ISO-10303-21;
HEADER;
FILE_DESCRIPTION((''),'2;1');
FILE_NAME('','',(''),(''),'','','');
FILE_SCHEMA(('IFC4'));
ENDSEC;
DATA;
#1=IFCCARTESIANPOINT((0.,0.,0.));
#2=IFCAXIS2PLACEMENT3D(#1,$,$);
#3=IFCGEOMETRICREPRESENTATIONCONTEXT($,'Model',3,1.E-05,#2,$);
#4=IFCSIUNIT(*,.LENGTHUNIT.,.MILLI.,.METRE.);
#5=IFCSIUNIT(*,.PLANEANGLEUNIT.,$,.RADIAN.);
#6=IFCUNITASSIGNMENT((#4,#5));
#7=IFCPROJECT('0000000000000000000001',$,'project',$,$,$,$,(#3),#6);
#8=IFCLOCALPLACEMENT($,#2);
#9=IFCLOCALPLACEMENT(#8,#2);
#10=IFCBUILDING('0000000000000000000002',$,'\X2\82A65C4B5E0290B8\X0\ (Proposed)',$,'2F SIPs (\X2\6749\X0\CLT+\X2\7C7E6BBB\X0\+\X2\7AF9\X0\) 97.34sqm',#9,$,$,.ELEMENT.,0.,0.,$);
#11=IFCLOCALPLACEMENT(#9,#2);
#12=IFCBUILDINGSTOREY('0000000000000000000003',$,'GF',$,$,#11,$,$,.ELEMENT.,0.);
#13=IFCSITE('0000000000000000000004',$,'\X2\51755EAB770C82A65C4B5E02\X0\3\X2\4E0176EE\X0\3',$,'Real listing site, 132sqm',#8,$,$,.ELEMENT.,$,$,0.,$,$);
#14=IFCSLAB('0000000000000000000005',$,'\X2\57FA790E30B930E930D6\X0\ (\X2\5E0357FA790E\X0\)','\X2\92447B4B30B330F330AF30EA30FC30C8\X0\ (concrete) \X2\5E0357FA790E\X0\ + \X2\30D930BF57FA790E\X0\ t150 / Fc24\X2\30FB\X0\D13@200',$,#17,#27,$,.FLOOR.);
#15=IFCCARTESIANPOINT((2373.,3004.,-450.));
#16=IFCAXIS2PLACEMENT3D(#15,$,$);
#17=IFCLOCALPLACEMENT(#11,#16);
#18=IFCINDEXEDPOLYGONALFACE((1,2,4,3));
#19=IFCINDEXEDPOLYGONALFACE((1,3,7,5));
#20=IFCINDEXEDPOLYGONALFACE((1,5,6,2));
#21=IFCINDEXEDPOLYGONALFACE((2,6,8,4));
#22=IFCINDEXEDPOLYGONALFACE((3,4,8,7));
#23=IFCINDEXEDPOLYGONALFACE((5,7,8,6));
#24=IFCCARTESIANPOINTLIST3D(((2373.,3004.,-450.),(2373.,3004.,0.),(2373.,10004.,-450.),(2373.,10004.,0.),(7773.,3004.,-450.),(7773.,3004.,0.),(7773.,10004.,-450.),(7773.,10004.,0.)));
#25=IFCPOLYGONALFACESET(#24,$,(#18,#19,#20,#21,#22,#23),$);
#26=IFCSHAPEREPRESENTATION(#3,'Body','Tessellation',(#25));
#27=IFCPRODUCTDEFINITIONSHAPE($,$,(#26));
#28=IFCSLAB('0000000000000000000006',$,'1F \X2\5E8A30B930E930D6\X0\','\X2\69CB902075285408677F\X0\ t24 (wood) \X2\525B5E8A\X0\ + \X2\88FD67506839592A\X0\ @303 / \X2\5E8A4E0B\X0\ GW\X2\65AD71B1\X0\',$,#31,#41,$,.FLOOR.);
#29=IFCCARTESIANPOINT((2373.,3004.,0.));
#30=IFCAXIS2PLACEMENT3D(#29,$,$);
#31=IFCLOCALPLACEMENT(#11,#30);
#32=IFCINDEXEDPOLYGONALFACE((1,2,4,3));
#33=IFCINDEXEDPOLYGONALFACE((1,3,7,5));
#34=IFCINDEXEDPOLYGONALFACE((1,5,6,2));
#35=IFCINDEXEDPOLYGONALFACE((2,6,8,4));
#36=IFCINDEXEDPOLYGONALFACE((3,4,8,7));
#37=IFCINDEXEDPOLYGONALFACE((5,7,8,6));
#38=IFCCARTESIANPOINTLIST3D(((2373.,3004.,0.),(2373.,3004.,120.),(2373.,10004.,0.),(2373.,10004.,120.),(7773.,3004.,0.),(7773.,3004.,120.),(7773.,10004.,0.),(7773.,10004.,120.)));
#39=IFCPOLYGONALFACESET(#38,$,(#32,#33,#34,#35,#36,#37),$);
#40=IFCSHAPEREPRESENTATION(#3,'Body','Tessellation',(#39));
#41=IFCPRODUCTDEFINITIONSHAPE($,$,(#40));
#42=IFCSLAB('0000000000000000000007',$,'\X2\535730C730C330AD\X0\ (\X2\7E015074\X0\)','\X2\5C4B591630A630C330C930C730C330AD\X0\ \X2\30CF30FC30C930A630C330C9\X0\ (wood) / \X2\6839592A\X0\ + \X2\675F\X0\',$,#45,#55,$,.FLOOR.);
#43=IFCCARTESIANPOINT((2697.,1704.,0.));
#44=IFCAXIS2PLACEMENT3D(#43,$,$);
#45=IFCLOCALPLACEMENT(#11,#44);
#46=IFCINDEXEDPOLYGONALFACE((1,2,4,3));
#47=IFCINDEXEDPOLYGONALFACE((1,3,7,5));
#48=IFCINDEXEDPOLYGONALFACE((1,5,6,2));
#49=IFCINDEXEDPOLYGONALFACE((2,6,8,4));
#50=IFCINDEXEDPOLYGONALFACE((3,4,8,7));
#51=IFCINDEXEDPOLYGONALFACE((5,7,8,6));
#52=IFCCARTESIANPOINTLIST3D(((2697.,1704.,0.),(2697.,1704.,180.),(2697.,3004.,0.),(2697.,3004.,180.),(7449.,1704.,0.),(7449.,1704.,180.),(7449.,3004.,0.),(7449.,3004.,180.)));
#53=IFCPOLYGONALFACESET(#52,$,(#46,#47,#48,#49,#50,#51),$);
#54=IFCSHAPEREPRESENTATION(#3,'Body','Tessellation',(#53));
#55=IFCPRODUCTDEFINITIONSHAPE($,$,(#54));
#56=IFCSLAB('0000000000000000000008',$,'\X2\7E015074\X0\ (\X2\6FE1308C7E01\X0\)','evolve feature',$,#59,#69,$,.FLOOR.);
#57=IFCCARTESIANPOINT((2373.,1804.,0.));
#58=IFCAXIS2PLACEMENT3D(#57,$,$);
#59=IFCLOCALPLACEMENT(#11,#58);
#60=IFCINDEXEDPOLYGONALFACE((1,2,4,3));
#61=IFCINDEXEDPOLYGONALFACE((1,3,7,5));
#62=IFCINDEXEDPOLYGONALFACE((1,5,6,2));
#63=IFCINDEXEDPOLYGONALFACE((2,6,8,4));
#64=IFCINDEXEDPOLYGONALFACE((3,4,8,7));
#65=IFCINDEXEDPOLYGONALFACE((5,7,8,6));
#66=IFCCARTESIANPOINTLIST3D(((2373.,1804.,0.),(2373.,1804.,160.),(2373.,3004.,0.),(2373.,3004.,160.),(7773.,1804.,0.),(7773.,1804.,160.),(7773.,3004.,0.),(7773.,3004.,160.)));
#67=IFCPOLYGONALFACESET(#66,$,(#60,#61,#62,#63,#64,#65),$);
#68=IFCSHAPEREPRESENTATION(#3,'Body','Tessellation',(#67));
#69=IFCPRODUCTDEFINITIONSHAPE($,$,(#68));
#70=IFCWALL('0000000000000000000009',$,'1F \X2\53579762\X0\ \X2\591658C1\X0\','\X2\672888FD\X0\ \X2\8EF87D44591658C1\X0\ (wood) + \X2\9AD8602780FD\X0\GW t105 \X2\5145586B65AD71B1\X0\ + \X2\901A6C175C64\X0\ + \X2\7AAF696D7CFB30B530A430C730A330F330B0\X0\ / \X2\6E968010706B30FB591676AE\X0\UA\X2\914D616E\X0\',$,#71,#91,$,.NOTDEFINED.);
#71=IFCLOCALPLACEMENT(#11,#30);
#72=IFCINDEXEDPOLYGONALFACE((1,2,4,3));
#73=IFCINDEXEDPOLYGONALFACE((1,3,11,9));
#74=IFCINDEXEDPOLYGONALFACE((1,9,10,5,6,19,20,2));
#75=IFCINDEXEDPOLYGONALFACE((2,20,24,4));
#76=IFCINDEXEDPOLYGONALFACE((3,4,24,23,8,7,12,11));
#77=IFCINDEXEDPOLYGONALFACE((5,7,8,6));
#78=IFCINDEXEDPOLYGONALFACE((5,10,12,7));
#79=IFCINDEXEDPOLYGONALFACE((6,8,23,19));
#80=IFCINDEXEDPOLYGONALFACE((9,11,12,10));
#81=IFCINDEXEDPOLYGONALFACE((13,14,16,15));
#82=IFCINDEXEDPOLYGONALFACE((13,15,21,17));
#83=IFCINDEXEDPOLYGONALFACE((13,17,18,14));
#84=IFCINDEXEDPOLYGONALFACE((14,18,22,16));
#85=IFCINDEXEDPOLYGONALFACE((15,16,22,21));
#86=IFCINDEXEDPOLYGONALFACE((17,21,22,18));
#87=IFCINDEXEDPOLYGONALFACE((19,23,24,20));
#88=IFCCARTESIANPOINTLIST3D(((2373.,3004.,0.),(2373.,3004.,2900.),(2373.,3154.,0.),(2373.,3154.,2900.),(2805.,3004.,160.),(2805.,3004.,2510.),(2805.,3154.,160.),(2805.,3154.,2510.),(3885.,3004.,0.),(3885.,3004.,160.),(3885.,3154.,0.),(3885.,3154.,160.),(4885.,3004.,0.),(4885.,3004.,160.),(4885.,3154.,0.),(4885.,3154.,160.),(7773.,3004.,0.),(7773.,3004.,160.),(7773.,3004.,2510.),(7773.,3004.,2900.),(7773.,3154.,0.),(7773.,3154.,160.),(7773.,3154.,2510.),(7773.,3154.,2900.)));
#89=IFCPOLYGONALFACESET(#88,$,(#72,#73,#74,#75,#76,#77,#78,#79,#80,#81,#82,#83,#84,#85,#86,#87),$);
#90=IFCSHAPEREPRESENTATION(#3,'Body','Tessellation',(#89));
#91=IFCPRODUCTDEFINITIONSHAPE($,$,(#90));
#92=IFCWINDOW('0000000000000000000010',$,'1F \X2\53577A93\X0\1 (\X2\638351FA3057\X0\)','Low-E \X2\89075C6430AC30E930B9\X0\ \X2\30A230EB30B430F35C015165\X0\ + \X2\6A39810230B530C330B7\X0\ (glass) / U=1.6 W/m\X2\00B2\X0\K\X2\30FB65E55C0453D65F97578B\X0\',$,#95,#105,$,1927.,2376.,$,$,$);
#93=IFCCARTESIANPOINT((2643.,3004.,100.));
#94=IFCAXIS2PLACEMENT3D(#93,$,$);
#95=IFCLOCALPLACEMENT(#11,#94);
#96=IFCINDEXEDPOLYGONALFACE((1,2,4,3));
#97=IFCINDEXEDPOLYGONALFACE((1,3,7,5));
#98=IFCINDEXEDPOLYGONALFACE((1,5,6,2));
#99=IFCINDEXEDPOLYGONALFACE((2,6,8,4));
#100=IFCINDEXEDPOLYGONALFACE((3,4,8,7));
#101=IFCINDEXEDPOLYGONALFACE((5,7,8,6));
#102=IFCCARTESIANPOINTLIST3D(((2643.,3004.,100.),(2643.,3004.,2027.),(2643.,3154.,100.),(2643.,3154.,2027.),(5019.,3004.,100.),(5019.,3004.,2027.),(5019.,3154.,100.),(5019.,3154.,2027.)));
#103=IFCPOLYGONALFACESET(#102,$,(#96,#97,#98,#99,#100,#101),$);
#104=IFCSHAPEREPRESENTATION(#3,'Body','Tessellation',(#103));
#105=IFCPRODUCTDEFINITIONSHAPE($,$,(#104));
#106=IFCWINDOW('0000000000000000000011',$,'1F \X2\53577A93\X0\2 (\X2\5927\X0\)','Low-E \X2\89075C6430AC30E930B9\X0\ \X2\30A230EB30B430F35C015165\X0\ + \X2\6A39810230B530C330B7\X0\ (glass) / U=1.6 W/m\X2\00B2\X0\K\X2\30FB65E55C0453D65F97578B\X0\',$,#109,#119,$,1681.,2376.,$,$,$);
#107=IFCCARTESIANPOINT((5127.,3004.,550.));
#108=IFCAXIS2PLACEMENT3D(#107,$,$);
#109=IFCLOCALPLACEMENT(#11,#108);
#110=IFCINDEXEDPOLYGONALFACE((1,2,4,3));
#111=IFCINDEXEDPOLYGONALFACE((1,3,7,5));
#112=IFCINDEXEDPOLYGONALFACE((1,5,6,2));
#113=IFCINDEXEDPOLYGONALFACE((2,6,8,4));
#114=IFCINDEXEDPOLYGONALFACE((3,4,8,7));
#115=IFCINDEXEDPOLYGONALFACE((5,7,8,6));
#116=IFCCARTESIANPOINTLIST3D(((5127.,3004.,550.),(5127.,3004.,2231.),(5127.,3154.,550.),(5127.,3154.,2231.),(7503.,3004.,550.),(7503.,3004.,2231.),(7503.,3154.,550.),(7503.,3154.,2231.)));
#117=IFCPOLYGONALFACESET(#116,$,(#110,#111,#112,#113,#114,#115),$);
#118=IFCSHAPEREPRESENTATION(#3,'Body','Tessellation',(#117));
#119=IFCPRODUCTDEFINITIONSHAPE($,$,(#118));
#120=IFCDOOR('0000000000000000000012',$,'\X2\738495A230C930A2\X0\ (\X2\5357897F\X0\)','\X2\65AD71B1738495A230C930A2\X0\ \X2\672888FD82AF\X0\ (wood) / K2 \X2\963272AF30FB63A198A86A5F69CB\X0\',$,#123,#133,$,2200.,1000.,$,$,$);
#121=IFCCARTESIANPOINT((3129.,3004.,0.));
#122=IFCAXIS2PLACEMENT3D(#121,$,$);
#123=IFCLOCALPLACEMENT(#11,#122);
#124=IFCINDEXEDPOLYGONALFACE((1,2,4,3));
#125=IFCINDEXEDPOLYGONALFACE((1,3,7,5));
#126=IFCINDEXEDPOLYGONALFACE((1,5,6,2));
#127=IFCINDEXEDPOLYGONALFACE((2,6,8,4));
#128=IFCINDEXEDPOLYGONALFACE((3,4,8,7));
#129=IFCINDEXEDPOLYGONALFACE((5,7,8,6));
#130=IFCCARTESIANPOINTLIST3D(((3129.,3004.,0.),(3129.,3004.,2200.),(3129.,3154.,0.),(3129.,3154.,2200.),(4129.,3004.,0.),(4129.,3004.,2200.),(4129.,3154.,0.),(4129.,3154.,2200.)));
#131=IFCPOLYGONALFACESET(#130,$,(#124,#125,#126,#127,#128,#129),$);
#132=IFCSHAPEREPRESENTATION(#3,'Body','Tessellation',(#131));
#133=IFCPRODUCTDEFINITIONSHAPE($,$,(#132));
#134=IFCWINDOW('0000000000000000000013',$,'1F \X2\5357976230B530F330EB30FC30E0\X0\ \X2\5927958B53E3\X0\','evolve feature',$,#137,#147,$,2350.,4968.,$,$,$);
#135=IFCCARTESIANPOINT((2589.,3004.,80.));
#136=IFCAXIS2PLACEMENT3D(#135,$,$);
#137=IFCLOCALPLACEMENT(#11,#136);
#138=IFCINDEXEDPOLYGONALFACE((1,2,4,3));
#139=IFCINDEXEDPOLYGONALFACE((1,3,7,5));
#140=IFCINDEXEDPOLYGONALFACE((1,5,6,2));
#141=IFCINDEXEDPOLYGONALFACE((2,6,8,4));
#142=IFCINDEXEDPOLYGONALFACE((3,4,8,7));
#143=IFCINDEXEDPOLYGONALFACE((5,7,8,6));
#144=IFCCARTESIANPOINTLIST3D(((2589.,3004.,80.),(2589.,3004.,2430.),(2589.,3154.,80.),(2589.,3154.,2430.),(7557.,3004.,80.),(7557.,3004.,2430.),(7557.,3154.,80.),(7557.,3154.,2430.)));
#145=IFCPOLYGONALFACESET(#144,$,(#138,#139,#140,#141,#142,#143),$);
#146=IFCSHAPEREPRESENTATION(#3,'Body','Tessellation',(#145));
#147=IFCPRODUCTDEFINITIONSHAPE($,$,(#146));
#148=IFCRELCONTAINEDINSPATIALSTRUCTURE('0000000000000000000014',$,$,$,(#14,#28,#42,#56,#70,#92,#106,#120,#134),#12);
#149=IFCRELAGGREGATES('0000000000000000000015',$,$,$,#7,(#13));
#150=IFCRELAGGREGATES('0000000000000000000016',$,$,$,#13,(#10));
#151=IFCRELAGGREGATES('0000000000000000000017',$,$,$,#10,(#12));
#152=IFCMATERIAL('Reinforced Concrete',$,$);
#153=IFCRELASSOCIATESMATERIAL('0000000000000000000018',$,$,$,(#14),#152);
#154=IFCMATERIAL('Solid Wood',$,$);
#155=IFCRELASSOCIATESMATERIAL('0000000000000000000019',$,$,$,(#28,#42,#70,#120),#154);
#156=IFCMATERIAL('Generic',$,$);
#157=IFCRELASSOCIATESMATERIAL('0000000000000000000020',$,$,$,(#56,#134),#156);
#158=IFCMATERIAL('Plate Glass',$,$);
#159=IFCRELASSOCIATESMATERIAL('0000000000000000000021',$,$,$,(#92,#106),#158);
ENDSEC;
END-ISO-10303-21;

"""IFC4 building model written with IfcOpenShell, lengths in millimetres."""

from ifc_helpers import new_model, si_unit, frame, frame_2d, origin, place, context, project, spatial, rectangle, extrude, material, element, fill, save


model = new_model("IFC4")

# Units and contexts
model_context = context("Model", 3, precision=1e-05, world=origin())
ifc_project = project(units=[si_unit("LENGTHUNIT", "METRE", prefix="MILLI"), si_unit("PLANEANGLEUNIT", "RADIAN")], contexts=[model_context])

# Site, building, storey
site_placement = place(None, origin())
site = spatial("IfcSite", under=ifc_project, at=site_placement, Name="兵庫県芦屋市3丁目3", ObjectType="Real listing site, 132sqm", CompositionType="ELEMENT", RefElevation=0.0)
building_placement = place(site_placement, origin())
building = spatial("IfcBuilding", under=site, at=building_placement, Name="芦屋市邸 (Proposed)", ObjectType="2F SIPs (杉CLT+籾殻+竹) 97.34sqm", CompositionType="ELEMENT", ElevationOfRefHeight=0.0, ElevationOfTerrain=0.0)
storey_placement = place(building_placement, origin())
storey = spatial("IfcBuildingStorey", under=building, at=storey_placement, Name="GF", CompositionType="ELEMENT", Elevation=0.0)

# Slabs
ifc_material_1 = material(Name="Reinforced Concrete")
slab_1_placement = place(storey_placement, frame((2373.0, 3004.0, -450.0)))
element("IfcSlab", 1, at=slab_1_placement, inside=storey, material=ifc_material_1, Name="基礎スラブ (布基礎)", Description="鉄筋コンクリート (concrete) 布基礎 + ベタ基礎 t150 / Fc24・D13@200", PredefinedType="FLOOR", context=model_context, shape_type="SweptSolid", body=[
    extrude(rectangle(XDim=5400.0, YDim=7000.0, at=frame_2d((2700.0, 3500.0))), frame((2373.0, 3004.0, -450.0)), (0.0, 0.0, 1.0), 450.0),
])
ifc_material_2 = material(Name="Solid Wood")
slab_2_placement = place(storey_placement, frame((2373.0, 3004.0, 0.0)))
element("IfcSlab", 2, at=slab_2_placement, inside=storey, material=ifc_material_2, Name="1F 床スラブ", Description="構造用合板 t24 (wood) 剛床 + 製材根太 @303 / 床下 GW断熱", PredefinedType="FLOOR", context=model_context, shape_type="SweptSolid", body=[
    extrude(rectangle(XDim=5400.0, YDim=7000.0, at=frame_2d((2700.0, 3500.0))), frame((2373.0, 3004.0, 0.0)), (0.0, 0.0, 1.0), 120.0),
])
slab_3_placement = place(storey_placement, frame((2697.0, 1704.0, 0.0)))
element("IfcSlab", 3, at=slab_3_placement, inside=storey, material=ifc_material_2, Name="南デッキ (縁側)", Description="屋外ウッドデッキ ハードウッド (wood) / 根太 + 束", PredefinedType="FLOOR", context=model_context, shape_type="SweptSolid", body=[
    extrude(rectangle(XDim=4752.0, YDim=1300.0, at=frame_2d((2376.0, 650.0))), frame((2697.0, 1704.0, 0.0)), (0.0, 0.0, 1.0), 180.0),
])
ifc_material_3 = material(Name="Generic")
slab_4_placement = place(storey_placement, frame((2373.0, 1804.0, 0.0)))
element("IfcSlab", 4, at=slab_4_placement, inside=storey, material=ifc_material_3, Name="縁側 (濡れ縁)", Description="evolve feature", PredefinedType="FLOOR", context=model_context, shape_type="SweptSolid", body=[
    extrude(rectangle(XDim=5400.0, YDim=1200.0, at=frame_2d((2700.0, 600.0))), frame((2373.0, 1804.0, 0.0)), (0.0, 0.0, 1.0), 160.0),
])

# Wall, openings, windows, door
wall_1_placement = place(storey_placement, frame((2373.0, 3004.0, 0.0)))
wall_1 = element("IfcWall", 5, at=wall_1_placement, inside=storey, material=ifc_material_2, Name="1F 南面 外壁", Description="木製 軸組外壁 (wood) + 高性能GW t105 充填断熱 + 通気層 + 窯業系サイディング / 準耐火・外皮UA配慮", PredefinedType="NOTDEFINED", context=model_context, shape_type="SweptSolid", body=[
    extrude(rectangle(XDim=5400.0, YDim=150.0, at=frame_2d((2700.0, 75.0))), frame((2373.0, 3004.0, 0.0)), (0.0, 0.0, 1.0), 2900.0),
])
opening_1_placement = place(storey_placement, frame((2643.0, 3004.0, 100.0)))
opening_1 = element("IfcOpeningElement", 6, at=opening_1_placement, cuts=wall_1, PredefinedType="NOTDEFINED", context=model_context, shape_type="SweptSolid", body=[
    extrude(rectangle(XDim=2376.0, YDim=150.0, at=frame_2d((1188.0, 75.0))), frame((2643.0, 3004.0, 100.0)), (0.0, 0.0, 1.0), 1927.0),
])
opening_2_placement = place(storey_placement, frame((5127.0, 3004.0, 550.0)))
opening_2 = element("IfcOpeningElement", 7, at=opening_2_placement, cuts=wall_1, PredefinedType="NOTDEFINED", context=model_context, shape_type="SweptSolid", body=[
    extrude(rectangle(XDim=2376.0, YDim=150.0, at=frame_2d((1188.0, 75.0))), frame((5127.0, 3004.0, 550.0)), (0.0, 0.0, 1.0), 1681.0),
])
opening_3_placement = place(storey_placement, frame((3129.0, 3004.0, 0.0)))
opening_3 = element("IfcOpeningElement", 8, at=opening_3_placement, cuts=wall_1, PredefinedType="NOTDEFINED", context=model_context, shape_type="SweptSolid", body=[
    extrude(rectangle(XDim=1000.0, YDim=150.0, at=frame_2d((500.0, 75.0))), frame((3129.0, 3004.0, 0.0)), (0.0, 0.0, 1.0), 2200.0),
])
opening_4_placement = place(storey_placement, frame((2589.0, 3004.0, 80.0)))
opening_4 = element("IfcOpeningElement", 9, at=opening_4_placement, cuts=wall_1, PredefinedType="NOTDEFINED", context=model_context, shape_type="SweptSolid", body=[
    extrude(rectangle(XDim=4968.0, YDim=150.0, at=frame_2d((2484.0, 75.0))), frame((2589.0, 3004.0, 80.0)), (0.0, 0.0, 1.0), 2350.0),
])
ifc_material_4 = material(Name="Plate Glass")
window_1_placement = place(storey_placement, frame((2643.0, 3004.0, 100.0)))
window_1 = element("IfcWindow", 10, at=window_1_placement, inside=storey, material=ifc_material_4, Name="1F 南窓1 (掃出し)", Description="Low-E 複層ガラス アルゴン封入 + 樹脂サッシ (glass) / U=1.6 W/m²K・日射取得型", OverallHeight=1927.0, OverallWidth=2376.0, context=model_context, shape_type="SweptSolid", body=[
    extrude(rectangle(XDim=2376.0, YDim=150.0, at=frame_2d((1188.0, 75.0))), frame((2643.0, 3004.0, 100.0)), (0.0, 0.0, 1.0), 1927.0),
])
fill(opening_1, window_1)
window_2_placement = place(storey_placement, frame((5127.0, 3004.0, 550.0)))
window_2 = element("IfcWindow", 11, at=window_2_placement, inside=storey, material=ifc_material_4, Name="1F 南窓2 (大)", Description="Low-E 複層ガラス アルゴン封入 + 樹脂サッシ (glass) / U=1.6 W/m²K・日射取得型", OverallHeight=1681.0, OverallWidth=2376.0, context=model_context, shape_type="SweptSolid", body=[
    extrude(rectangle(XDim=2376.0, YDim=150.0, at=frame_2d((1188.0, 75.0))), frame((5127.0, 3004.0, 550.0)), (0.0, 0.0, 1.0), 1681.0),
])
fill(opening_2, window_2)
door_placement = place(storey_placement, frame((3129.0, 3004.0, 0.0)))
door = element("IfcDoor", 12, at=door_placement, inside=storey, material=ifc_material_2, Name="玄関ドア (南西)", Description="断熱玄関ドア 木製芯 (wood) / K2 防犯・採風機構", OverallHeight=2200.0, OverallWidth=1000.0, context=model_context, shape_type="SweptSolid", body=[
    extrude(rectangle(XDim=1000.0, YDim=150.0, at=frame_2d((500.0, 75.0))), frame((3129.0, 3004.0, 0.0)), (0.0, 0.0, 1.0), 2200.0),
])
fill(opening_3, door)
window_3_placement = place(storey_placement, frame((2589.0, 3004.0, 80.0)))
window_3 = element("IfcWindow", 13, at=window_3_placement, inside=storey, material=ifc_material_3, Name="1F 南面サンルーム 大開口", Description="evolve feature", OverallHeight=2350.0, OverallWidth=4968.0, context=model_context, shape_type="SweptSolid", body=[
    extrude(rectangle(XDim=4968.0, YDim=150.0, at=frame_2d((2484.0, 75.0))), frame((2589.0, 3004.0, 80.0)), (0.0, 0.0, 1.0), 2350.0),
])
fill(opening_4, window_3)

save(model, "model.ifc")
